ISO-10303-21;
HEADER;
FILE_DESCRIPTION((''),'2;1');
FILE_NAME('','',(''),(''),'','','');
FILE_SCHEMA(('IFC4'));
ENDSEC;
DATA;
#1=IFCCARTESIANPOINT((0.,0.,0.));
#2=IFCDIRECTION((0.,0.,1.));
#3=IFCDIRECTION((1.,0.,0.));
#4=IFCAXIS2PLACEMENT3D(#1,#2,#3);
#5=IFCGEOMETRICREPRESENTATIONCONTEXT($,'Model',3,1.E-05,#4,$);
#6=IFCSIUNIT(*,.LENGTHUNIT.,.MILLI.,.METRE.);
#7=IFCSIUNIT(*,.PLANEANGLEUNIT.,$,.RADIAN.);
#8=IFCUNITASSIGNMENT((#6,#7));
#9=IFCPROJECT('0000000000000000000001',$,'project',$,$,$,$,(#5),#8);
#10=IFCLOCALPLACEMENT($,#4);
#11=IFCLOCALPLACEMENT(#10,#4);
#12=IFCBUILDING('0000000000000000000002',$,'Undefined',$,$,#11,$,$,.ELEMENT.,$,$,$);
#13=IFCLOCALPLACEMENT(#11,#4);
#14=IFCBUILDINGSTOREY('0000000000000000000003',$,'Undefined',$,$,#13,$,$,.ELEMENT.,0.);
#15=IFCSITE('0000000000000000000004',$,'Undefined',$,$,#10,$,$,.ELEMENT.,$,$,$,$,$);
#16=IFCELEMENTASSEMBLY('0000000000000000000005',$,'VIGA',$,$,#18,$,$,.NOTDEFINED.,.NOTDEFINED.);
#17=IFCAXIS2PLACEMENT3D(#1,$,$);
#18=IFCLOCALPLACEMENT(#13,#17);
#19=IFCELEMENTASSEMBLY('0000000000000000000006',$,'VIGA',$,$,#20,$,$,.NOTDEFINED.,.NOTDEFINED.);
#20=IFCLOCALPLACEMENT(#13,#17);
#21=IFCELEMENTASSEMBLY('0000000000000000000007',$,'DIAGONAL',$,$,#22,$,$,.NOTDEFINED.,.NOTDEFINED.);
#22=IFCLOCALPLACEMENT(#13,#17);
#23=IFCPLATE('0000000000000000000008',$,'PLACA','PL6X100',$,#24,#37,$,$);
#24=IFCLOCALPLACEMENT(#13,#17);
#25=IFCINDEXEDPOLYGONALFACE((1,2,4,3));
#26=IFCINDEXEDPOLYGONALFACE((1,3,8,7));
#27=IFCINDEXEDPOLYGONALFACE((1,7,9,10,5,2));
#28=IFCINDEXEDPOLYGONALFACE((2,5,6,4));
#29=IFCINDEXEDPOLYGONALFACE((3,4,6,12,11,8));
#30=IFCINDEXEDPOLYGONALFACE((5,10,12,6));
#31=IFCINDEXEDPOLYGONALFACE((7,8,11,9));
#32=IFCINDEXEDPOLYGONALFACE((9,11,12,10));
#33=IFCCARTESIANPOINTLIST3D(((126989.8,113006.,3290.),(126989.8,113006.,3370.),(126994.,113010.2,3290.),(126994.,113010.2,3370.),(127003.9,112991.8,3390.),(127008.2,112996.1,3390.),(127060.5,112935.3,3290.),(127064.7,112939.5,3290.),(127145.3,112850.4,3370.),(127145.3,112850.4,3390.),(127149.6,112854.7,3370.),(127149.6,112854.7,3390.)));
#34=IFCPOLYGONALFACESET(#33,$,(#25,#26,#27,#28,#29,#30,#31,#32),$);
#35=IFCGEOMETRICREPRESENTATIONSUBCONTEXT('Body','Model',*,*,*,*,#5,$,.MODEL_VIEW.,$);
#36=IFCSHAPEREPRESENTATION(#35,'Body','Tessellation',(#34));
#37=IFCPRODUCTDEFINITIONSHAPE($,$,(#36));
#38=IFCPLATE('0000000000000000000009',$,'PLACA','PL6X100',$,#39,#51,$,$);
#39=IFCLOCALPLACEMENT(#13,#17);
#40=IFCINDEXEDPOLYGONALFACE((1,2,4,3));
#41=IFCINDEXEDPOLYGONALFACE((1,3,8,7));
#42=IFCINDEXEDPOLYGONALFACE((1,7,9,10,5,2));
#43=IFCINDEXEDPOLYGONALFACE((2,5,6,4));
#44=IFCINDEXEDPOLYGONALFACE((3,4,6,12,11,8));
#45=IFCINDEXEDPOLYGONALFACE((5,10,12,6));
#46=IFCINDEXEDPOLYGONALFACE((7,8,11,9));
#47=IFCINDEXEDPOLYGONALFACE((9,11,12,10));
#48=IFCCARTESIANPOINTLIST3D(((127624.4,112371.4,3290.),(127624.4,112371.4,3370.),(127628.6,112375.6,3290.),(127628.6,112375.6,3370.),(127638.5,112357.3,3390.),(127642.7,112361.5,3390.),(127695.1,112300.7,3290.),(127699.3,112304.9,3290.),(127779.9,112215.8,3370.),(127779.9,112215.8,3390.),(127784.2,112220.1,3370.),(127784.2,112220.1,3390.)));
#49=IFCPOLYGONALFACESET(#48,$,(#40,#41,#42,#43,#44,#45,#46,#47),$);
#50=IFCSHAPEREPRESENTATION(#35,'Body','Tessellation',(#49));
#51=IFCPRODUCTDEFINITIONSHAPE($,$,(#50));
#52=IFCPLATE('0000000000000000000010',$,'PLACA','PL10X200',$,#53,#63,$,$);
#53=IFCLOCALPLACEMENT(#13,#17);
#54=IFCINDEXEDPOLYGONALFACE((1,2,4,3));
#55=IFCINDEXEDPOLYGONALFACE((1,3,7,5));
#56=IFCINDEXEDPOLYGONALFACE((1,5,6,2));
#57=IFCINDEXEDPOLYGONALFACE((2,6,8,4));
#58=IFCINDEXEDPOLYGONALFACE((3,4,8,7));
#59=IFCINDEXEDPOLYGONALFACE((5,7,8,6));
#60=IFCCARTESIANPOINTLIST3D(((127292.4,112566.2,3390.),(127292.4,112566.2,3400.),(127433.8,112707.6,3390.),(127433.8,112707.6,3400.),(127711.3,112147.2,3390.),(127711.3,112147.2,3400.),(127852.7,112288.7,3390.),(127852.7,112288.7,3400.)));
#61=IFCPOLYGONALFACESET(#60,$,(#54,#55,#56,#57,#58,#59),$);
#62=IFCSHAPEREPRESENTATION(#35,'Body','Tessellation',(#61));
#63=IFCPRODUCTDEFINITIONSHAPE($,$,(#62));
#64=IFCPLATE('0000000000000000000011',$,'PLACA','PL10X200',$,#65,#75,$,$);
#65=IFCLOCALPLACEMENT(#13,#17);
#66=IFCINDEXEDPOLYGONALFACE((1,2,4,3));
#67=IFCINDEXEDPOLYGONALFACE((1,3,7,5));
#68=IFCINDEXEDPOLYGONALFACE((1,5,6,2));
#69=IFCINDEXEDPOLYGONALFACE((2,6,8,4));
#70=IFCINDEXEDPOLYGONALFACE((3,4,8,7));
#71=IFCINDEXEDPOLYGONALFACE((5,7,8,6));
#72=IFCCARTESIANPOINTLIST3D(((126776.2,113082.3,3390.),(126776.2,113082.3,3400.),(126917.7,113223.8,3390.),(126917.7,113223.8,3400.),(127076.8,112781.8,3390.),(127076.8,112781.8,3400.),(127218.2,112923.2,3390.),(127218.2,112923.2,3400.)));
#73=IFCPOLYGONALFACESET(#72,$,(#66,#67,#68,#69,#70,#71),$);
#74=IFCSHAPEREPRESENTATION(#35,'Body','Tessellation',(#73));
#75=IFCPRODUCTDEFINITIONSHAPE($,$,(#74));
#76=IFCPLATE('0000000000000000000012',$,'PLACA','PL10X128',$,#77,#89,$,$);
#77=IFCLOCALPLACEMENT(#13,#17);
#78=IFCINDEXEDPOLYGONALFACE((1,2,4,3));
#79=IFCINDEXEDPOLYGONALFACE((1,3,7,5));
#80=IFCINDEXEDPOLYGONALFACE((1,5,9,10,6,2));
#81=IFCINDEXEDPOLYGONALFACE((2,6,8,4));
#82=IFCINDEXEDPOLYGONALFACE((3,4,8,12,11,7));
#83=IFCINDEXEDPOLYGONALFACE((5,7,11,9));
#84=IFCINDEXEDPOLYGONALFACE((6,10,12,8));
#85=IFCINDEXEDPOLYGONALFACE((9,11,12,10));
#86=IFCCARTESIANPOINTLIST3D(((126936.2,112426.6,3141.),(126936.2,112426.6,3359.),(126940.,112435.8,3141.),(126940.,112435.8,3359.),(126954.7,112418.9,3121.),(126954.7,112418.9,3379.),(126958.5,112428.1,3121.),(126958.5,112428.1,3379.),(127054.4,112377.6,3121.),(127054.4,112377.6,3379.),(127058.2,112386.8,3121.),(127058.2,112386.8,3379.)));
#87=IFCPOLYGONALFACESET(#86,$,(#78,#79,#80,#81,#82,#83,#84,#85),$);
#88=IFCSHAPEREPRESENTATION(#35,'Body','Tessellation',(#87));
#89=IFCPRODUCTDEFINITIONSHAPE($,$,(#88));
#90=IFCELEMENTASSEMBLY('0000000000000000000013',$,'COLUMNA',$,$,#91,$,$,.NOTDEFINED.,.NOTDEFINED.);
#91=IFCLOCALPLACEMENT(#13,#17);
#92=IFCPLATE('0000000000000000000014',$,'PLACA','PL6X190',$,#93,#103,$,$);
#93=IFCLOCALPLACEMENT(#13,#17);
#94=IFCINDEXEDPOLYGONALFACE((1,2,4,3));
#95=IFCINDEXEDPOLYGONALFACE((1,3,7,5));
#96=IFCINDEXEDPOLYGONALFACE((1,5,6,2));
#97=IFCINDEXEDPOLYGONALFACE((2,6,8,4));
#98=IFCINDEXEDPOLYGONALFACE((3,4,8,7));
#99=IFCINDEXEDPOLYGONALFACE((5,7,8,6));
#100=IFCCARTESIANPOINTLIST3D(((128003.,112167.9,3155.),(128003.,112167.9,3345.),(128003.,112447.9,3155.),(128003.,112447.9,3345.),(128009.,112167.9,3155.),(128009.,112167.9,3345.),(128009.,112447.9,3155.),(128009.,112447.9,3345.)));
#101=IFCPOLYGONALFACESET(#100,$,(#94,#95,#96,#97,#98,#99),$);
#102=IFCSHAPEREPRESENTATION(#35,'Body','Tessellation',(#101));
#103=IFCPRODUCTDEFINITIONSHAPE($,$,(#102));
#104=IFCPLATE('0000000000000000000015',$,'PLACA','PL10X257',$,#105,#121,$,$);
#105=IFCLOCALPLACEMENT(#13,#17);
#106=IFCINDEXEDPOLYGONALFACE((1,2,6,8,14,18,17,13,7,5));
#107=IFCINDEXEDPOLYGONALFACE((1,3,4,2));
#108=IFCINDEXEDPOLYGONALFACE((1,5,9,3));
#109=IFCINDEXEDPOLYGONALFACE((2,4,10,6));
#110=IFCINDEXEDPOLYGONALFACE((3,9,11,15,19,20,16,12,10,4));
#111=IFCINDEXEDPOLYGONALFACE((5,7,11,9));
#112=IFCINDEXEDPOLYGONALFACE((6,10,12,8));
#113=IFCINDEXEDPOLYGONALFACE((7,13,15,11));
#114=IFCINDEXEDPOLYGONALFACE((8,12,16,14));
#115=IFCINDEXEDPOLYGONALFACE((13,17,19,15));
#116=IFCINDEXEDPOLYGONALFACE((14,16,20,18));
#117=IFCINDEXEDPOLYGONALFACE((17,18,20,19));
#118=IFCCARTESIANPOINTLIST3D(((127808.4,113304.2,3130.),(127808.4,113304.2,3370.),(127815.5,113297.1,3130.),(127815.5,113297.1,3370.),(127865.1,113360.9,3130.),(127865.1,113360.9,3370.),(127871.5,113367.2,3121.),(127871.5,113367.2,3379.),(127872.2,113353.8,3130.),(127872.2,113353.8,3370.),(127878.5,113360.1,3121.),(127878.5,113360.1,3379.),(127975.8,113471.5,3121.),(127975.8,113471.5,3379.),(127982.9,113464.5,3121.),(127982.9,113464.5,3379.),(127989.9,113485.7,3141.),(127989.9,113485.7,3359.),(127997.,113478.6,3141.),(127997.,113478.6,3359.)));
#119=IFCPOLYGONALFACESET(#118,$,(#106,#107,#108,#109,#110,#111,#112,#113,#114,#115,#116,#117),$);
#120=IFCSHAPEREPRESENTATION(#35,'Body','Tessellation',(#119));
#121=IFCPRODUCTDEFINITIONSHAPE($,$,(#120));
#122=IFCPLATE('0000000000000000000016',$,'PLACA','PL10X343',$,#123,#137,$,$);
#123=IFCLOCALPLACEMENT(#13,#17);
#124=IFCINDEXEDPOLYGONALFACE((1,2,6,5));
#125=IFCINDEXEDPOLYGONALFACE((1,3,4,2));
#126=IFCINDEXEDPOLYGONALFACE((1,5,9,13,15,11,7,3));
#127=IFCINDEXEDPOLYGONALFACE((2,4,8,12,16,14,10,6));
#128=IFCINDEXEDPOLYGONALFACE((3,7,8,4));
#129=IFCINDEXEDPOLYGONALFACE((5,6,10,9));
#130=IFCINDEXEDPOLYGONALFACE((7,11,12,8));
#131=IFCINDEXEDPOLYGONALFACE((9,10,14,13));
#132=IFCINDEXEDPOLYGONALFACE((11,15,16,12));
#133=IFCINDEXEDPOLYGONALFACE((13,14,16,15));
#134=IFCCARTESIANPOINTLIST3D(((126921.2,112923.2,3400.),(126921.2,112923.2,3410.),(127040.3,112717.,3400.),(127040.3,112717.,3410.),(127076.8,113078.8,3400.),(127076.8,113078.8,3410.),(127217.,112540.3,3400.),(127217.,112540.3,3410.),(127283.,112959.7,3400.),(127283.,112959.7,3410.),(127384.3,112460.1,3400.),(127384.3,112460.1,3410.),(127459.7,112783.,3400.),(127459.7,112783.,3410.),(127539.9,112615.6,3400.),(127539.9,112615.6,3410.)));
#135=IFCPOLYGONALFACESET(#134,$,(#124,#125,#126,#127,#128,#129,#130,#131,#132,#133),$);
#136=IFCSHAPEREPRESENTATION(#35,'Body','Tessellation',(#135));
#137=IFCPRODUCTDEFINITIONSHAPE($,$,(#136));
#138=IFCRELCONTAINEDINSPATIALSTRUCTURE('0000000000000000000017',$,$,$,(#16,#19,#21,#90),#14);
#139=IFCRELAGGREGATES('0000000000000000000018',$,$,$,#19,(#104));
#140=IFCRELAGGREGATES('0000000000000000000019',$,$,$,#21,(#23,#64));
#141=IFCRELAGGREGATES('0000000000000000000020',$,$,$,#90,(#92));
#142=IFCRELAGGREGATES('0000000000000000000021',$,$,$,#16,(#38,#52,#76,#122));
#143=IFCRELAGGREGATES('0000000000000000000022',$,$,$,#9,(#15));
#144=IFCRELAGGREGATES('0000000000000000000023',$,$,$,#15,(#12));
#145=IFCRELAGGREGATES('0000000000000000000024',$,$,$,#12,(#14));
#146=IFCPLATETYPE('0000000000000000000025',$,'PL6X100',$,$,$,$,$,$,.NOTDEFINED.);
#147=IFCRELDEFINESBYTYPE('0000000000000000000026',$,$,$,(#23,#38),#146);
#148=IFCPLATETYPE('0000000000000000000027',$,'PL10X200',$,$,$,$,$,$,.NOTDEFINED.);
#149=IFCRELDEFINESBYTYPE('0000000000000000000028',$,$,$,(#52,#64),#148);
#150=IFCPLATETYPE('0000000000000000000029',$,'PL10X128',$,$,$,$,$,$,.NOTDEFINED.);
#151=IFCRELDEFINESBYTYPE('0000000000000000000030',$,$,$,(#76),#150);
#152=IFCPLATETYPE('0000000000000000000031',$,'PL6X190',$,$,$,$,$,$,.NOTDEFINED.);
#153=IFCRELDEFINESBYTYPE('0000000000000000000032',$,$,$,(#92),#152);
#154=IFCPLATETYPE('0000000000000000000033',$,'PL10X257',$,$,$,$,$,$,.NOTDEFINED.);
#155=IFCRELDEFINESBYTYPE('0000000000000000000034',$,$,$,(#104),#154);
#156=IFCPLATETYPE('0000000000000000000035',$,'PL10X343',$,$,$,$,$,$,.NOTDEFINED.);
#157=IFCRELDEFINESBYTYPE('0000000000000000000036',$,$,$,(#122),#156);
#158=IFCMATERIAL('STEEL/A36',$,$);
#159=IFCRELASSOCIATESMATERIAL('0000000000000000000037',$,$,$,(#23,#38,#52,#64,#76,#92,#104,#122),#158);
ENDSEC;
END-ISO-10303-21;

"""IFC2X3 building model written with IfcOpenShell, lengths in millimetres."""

from ifc_helpers import new_model, si_unit, frame, origin_with_axes, place, context, subcontext, project, spatial, polyline, outline, extrude, material, type_object, element, aggregate, save


model = new_model("IFC2X3")

# Units and contexts
model_context = context("Model", 3, precision=1e-05, world=origin_with_axes())
body_context = subcontext(model_context, "Body", "Model", "MODEL_VIEW")
ifc_project = project(units=[si_unit("LENGTHUNIT", "METRE", prefix="MILLI"), si_unit("PLANEANGLEUNIT", "RADIAN")], contexts=[model_context])

# Site, building, storey
site_placement = place(None, origin_with_axes())
site = spatial("IfcSite", under=ifc_project, at=site_placement, Name="Undefined", CompositionType="ELEMENT")
building_placement = place(site_placement, origin_with_axes())
building = spatial("IfcBuilding", under=site, at=building_placement, Name="Undefined", CompositionType="ELEMENT")
storey_placement = place(building_placement, origin_with_axes())
storey = spatial("IfcBuildingStorey", under=building, at=storey_placement, Name="Undefined", CompositionType="ELEMENT", Elevation=0.0)

# Element assembly
assembly_1_placement = place(storey_placement, origin_with_axes())
assembly_1 = element("IfcElementAssembly", 1, at=assembly_1_placement, inside=storey, Name="VIGA", AssemblyPlace="NOTDEFINED", PredefinedType="NOTDEFINED")
ifc_material_1 = material(Name="STEEL/A36")

# Element assembly
assembly_2_placement = place(storey_placement, origin_with_axes())
assembly_2 = element("IfcElementAssembly", 2, at=assembly_2_placement, inside=storey, Name="VIGA", AssemblyPlace="NOTDEFINED", PredefinedType="NOTDEFINED")

# Element assembly
assembly_3_placement = place(storey_placement, origin_with_axes())
assembly_3 = element("IfcElementAssembly", 3, at=assembly_3_placement, inside=storey, Name="DIAGONAL", AssemblyPlace="NOTDEFINED", PredefinedType="NOTDEFINED")

# Plates
plate_type_1 = type_object("IfcPlateType", Name="PL6X100", PredefinedType="NOTDEFINED")
plate_1_placement = place(assembly_3_placement, frame((127147.5, 112852.5, 3290.0), z_axis=(0.707107, 0.707107, 0.0), x_axis=(-0.707107, 0.707107, 0.0)))
plate_1 = element("IfcPlate", 4, at=plate_1_placement, type_object=plate_type_1, material=ifc_material_1, Name="PLACA", Description="PL6X100", context=body_context, shape_type="SweptSolid", body=[
    extrude(outline(polyline([(0.0, 80.0), (120.0, 0.0), (220.0, 0.0), (220.0, 80.0), (200.0, 100.0), (0.0, 100.0), (0.0, 80.0)])), frame((0.0, 0.0, -3.0), z_axis=(0.0, 0.0, 1.0), x_axis=(1.0, 0.0, 0.0)), (0.0, 0.0, 1.0), 6.0),
])
plate_2_placement = place(assembly_1_placement, frame((127782.0, 112218.0, 3290.0), z_axis=(0.707107, 0.707107, 0.0), x_axis=(-0.707107, 0.707107, 0.0)))
plate_2 = element("IfcPlate", 5, at=plate_2_placement, type_object=plate_type_1, material=ifc_material_1, Name="PLACA", Description="PL6X100", context=body_context, shape_type="SweptSolid", body=[
    extrude(outline(polyline([(0.0, 80.0), (120.0, 0.0), (220.0, 0.0), (220.0, 80.0), (200.0, 100.0), (0.0, 100.0), (0.0, 80.0)])), frame((0.0, 0.0, -3.0), z_axis=(0.0, 0.0, 1.0), x_axis=(1.0, 0.0, 0.0)), (0.0, 0.0, 1.0), 6.0),
])
plate_type_2 = type_object("IfcPlateType", Name="PL10X200", PredefinedType="NOTDEFINED")
plate_3_placement = place(assembly_1_placement, frame((127782.0, 112218.0, 3395.0), z_axis=(0.0, 0.0, -1.0), x_axis=(-0.707107, 0.707107, 0.0)))
plate_3 = element("IfcPlate", 6, at=plate_3_placement, type_object=plate_type_2, material=ifc_material_1, Name="PLACA", Description="PL10X200", context=body_context, shape_type="SweptSolid", body=[
    extrude(outline(polyline([(0.0, -100.0), (0.0, 100.0), (592.4, 100.0), (592.4, -100.0), (0.0, -100.0)])), frame((0.0, 0.0, -5.0), z_axis=(0.0, 0.0, 1.0), x_axis=(1.0, 0.0, 0.0)), (0.0, 0.0, 1.0), 10.0),
])
plate_4_placement = place(assembly_3_placement, frame((127147.5, 112852.5, 3395.0), z_axis=(0.0, 0.0, 1.0), x_axis=(-0.707107, 0.707107, 0.0)))
plate_4 = element("IfcPlate", 7, at=plate_4_placement, type_object=plate_type_2, material=ifc_material_1, Name="PLACA", Description="PL10X200", context=body_context, shape_type="SweptSolid", body=[
    extrude(outline(polyline([(0.0, -100.0), (0.0, 100.0), (425.0, 100.0), (425.0, -100.0), (0.0, -100.0)])), frame((0.0, 0.0, -5.0), z_axis=(0.0, 0.0, 1.0), x_axis=(1.0, 0.0, 0.0)), (0.0, 0.0, 1.0), 10.0),
])
plate_type_3 = type_object("IfcPlateType", Name="PL10X128", PredefinedType="NOTDEFINED")
plate_5_placement = place(assembly_1_placement, frame((126938.1, 112431.2, 3121.0), z_axis=(-0.382672, -0.923884, 0.0), x_axis=(0.923884, -0.382672, 0.0)))
plate_5 = element("IfcPlate", 8, at=plate_5_placement, type_object=plate_type_3, material=ifc_material_1, Name="PLACA", Description="PL10X128", context=body_context, shape_type="SweptSolid", body=[
    extrude(outline(polyline([(0.0, 20.0), (20.0, 0.0), (127.9, 0.0), (127.9, 258.0), (20.0, 258.0), (0.0, 238.0), (0.0, 20.0)])), frame((0.0, 0.0, -5.0), z_axis=(0.0, 0.0, 1.0), x_axis=(1.0, 0.0, 0.0)), (0.0, 0.0, 1.0), 10.0),
])

# Element assembly, plate
assembly_4_placement = place(storey_placement, origin_with_axes())
assembly_4 = element("IfcElementAssembly", 9, at=assembly_4_placement, inside=storey, Name="COLUMNA", AssemblyPlace="NOTDEFINED", PredefinedType="NOTDEFINED")
plate_type_4 = type_object("IfcPlateType", Name="PL6X190", PredefinedType="NOTDEFINED")
plate_6_placement = place(assembly_4_placement, frame((128006.0, 112447.9, 3250.0), z_axis=(-1.0, 0.0, 0.0), x_axis=(0.0, -1.0, 0.0)))
plate_6 = element("IfcPlate", 10, at=plate_6_placement, type_object=plate_type_4, material=ifc_material_1, Name="PLACA", Description="PL6X190", context=body_context, shape_type="SweptSolid", body=[
    extrude(outline(polyline([(0.0, -95.0), (0.0, 95.0), (280.0, 95.0), (280.0, -95.0), (0.0, -95.0)])), frame((0.0, 0.0, -3.0), z_axis=(0.0, 0.0, 1.0), x_axis=(1.0, 0.0, 0.0)), (0.0, 0.0, 1.0), 6.0),
])

# Plates
plate_type_5 = type_object("IfcPlateType", Name="PL10X257", PredefinedType="NOTDEFINED")
plate_7_placement = place(assembly_2_placement, frame((127993.5, 113482.1, 3141.0), z_axis=(-0.707107, 0.707107, 0.0), x_axis=(-0.5, -0.5, -0.707107)))
plate_7 = element("IfcPlate", 11, at=plate_7_placement, type_object=plate_type_5, material=ifc_material_1, Name="PLACA", Description="PL10X257", context=body_context, shape_type="SweptSolid", body=[
    extrude(outline(polyline([(0.0, 0.0), (28.3, 0.0), (132.6, 104.3), (132.6, 104.3), (132.6, 117.1), (189.3, 173.7), (19.6, 343.4), (-37.1, 286.8), (-49.8, 286.8), (-49.8, 286.8), (-154.1, 182.4), (-154.1, 154.1), (0.0, 0.0)])), frame((0.0, 0.0, -5.0), z_axis=(0.0, 0.0, 1.0), x_axis=(1.0, 0.0, 0.0)), (0.0, 0.0, 1.0), 10.0),
])
aggregate(assembly_2, [plate_7])
plate_type_6 = type_object("IfcPlateType", Name="PL10X343", PredefinedType="NOTDEFINED")
plate_8_placement = place(assembly_1_placement, frame((127217.0, 112540.3, 3405.0), z_axis=(0.0, 0.0, -1.0), x_axis=(-0.707107, 0.707107, 0.0)))
plate_8 = element("IfcPlate", 12, at=plate_8_placement, type_object=plate_type_6, material=ifc_material_1, Name="PLACA", Description="PL10X343", context=body_context, shape_type="SweptSolid", body=[
    extrude(outline(polyline([(0.0, 0.0), (250.0, 0.0), (480.0, 61.6), (480.0, 281.6), (250.0, 343.3), (0.0, 343.3), (-175.0, 281.6), (-175.0, 61.6), (0.0, 0.0)])), frame((0.0, 0.0, -5.0), z_axis=(0.0, 0.0, 1.0), x_axis=(1.0, 0.0, 0.0)), (0.0, 0.0, 1.0), 10.0),
])

aggregate(assembly_3, [plate_1, plate_4])

aggregate(assembly_4, [plate_6])
aggregate(assembly_1, [plate_2, plate_3, plate_5, plate_8])

save(model, "model.ifc")
